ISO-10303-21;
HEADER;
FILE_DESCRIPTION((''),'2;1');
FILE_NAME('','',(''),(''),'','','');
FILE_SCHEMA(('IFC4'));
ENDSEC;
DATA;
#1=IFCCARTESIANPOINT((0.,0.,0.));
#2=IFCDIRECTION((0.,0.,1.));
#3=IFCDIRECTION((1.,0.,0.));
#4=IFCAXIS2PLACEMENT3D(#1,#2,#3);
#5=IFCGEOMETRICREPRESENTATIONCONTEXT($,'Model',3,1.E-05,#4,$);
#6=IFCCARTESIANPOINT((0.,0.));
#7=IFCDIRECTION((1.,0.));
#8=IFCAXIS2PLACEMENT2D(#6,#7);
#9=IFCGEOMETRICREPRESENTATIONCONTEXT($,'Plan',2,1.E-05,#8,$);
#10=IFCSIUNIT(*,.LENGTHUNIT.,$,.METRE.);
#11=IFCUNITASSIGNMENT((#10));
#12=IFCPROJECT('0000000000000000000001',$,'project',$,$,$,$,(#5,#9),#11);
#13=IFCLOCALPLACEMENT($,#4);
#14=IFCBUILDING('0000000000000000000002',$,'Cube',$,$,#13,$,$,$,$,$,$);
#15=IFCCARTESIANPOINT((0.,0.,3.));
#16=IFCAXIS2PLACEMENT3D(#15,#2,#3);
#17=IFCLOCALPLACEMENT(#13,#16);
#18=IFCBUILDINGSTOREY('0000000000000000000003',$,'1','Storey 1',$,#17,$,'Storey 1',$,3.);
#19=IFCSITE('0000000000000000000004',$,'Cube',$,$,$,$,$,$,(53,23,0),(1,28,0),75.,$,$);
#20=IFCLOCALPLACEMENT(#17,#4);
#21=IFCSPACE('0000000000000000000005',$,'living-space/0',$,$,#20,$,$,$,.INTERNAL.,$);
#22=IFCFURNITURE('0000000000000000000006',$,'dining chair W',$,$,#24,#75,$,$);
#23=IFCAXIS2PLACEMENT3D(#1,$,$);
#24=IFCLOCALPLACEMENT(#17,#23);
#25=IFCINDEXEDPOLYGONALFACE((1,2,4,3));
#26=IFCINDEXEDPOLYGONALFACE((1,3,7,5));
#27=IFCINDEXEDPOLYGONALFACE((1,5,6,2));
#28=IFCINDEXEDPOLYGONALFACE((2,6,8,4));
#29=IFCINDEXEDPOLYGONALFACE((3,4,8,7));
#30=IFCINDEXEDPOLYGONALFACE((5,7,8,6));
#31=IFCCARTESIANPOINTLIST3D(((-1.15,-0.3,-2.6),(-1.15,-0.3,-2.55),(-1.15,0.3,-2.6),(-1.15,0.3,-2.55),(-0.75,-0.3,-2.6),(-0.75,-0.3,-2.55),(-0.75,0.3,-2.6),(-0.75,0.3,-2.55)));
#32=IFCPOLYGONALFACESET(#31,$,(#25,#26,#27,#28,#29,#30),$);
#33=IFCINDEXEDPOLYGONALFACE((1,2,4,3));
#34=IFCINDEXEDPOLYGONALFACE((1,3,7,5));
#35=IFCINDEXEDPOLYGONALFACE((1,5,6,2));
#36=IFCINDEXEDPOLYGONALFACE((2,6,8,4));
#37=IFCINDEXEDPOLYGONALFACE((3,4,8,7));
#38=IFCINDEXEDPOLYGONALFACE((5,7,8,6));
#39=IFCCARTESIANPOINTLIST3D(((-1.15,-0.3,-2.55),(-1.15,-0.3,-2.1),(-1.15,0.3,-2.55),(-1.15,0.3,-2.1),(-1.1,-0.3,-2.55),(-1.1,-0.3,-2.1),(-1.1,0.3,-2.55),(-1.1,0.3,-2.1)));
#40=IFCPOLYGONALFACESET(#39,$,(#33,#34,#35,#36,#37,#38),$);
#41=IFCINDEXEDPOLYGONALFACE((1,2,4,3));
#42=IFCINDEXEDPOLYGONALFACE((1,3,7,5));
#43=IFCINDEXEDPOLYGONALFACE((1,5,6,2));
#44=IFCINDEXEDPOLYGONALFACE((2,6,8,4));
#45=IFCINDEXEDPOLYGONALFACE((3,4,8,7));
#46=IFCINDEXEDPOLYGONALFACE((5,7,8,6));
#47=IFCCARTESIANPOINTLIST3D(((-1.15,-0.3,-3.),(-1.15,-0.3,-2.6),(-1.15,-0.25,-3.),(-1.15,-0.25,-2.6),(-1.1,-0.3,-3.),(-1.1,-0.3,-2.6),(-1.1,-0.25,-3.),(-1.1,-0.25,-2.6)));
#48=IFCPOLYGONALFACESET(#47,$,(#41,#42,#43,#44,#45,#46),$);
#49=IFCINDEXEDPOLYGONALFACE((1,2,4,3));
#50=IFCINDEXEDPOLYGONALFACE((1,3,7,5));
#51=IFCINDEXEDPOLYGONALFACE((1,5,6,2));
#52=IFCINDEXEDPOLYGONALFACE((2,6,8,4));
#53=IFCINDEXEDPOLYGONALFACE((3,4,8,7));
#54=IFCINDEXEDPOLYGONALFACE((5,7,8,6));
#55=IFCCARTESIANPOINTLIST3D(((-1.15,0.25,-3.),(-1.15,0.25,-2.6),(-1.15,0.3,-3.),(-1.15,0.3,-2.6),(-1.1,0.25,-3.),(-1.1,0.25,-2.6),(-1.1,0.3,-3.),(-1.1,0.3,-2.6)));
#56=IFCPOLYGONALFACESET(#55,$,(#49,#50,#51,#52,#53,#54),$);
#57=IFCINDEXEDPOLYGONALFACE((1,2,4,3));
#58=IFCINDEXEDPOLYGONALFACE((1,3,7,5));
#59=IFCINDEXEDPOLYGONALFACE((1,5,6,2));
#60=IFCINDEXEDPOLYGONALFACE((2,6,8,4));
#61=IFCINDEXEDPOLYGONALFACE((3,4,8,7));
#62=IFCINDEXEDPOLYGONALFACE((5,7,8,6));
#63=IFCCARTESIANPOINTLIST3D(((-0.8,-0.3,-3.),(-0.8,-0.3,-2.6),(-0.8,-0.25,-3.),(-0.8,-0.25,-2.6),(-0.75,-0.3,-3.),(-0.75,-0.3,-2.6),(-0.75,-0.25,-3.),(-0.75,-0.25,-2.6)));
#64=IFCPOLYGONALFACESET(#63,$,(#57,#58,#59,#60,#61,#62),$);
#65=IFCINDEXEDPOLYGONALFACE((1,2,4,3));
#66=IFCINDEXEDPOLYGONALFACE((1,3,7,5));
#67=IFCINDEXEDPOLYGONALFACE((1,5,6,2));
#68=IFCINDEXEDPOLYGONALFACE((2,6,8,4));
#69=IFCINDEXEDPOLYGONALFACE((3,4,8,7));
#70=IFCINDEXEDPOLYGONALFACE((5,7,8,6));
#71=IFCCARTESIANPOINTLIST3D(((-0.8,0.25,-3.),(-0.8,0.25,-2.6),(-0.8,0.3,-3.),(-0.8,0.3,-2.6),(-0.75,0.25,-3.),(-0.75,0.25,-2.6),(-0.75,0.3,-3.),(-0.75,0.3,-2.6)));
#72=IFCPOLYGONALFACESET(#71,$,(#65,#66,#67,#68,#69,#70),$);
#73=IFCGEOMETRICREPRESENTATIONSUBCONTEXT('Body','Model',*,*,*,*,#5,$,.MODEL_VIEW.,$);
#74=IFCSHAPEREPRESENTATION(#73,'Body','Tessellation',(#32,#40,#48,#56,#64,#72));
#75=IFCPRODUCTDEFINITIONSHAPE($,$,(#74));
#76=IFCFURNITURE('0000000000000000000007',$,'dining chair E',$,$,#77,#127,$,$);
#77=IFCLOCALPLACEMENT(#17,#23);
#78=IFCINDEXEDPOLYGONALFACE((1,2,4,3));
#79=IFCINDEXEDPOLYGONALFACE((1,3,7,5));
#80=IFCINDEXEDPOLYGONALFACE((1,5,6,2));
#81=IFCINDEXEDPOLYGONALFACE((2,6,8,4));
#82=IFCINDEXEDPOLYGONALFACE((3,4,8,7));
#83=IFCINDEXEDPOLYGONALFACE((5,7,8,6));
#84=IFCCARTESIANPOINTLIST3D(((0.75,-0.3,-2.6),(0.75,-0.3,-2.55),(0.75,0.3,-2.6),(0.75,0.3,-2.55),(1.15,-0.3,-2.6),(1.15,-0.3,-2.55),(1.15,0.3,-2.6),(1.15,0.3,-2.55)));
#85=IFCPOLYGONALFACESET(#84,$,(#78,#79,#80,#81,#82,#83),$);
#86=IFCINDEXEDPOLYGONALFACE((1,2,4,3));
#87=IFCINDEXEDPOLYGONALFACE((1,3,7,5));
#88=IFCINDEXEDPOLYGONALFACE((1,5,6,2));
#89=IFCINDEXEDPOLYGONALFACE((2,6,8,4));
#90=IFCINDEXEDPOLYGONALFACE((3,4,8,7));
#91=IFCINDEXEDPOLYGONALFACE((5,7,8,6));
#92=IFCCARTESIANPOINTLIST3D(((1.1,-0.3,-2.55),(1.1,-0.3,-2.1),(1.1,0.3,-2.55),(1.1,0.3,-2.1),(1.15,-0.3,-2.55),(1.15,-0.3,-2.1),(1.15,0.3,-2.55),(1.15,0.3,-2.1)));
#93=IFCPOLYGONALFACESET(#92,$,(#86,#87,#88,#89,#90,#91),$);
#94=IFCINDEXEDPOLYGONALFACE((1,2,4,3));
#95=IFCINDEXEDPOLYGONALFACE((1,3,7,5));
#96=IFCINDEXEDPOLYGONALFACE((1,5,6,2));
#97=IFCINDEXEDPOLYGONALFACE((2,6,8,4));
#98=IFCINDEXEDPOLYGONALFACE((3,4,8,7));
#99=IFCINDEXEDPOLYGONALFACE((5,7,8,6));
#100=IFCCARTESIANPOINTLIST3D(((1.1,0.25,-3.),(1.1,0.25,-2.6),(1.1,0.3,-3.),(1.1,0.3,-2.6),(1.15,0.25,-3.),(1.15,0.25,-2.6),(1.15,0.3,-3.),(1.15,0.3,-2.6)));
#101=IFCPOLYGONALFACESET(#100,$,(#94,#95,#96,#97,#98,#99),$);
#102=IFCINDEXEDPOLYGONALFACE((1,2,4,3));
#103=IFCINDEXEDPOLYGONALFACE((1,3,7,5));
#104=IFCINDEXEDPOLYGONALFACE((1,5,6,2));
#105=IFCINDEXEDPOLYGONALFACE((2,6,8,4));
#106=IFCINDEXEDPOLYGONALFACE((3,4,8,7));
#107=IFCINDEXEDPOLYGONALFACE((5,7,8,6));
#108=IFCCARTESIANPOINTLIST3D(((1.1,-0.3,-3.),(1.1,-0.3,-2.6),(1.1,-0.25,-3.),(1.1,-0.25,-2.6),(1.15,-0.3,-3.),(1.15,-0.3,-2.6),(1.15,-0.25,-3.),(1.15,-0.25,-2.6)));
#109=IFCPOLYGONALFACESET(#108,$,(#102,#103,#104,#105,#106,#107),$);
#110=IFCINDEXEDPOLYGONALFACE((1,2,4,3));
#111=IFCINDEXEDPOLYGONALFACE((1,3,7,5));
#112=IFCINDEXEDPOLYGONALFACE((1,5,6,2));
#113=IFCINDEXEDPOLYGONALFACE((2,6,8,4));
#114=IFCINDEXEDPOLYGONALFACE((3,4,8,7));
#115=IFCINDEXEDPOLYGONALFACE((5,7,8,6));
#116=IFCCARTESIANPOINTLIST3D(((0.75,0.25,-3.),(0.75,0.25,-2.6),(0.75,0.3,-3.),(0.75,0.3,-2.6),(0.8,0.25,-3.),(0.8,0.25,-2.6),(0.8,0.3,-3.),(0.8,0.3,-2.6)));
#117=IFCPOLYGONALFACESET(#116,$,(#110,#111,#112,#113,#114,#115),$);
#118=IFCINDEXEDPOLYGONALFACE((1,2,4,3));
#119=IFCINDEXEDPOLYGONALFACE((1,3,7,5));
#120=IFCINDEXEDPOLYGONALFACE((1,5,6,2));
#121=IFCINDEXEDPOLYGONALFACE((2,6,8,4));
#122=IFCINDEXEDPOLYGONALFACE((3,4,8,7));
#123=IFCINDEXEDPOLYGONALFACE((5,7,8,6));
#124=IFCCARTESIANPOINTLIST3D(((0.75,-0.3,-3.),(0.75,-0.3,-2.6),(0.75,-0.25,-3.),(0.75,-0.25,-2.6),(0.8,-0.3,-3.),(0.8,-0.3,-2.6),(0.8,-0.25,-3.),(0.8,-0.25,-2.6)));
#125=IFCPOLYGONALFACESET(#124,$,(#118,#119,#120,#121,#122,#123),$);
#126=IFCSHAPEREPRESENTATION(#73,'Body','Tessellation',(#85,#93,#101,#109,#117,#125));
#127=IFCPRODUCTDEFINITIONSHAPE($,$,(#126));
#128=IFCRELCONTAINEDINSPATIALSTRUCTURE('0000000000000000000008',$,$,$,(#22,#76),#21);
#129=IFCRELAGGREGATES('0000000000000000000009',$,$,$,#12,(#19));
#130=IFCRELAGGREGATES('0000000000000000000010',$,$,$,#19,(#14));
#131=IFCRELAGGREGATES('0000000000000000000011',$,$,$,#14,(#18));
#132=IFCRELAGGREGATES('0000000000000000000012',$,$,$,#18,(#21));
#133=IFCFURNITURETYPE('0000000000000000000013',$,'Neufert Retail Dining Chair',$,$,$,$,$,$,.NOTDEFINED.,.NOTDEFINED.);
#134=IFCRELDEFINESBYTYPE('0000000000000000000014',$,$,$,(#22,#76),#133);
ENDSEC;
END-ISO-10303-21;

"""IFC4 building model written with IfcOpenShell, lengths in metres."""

from ifc_helpers import new_model, entity, si_unit, frame, origin_with_axes, origin_2d_with_axis, place, context, subcontext, project, spatial, line, indexed_curve, outline, extrude, shape, source, transform, mapped, type_object, type_shapes, element, save


model = new_model("IFC4")

# Units and contexts
model_context = context("Model", 3, precision=1e-05, world=origin_with_axes())
plan_context = context("Plan", 2, precision=1e-05, world=origin_2d_with_axis())
body_context_1 = subcontext(model_context, "Body", "Model", "MODEL_VIEW")
body_context_2 = subcontext(plan_context, "Body", "Plan", "PLAN_VIEW")
ifc_project = project(units=[si_unit("LENGTHUNIT", "METRE")], contexts=[model_context, plan_context])

# Site, building, storey
site = spatial("IfcSite", under=ifc_project, Name="Cube", RefLatitude=(53, 23, 0), RefLongitude=(1, 28, 0), RefElevation=75.0)
building_placement = place(None, origin_with_axes())
building = spatial("IfcBuilding", under=site, at=building_placement, Name="Cube")
storey_placement = place(building_placement, frame((0.0, 0.0, 3.0), z_axis=(0.0, 0.0, 1.0), x_axis=(1.0, 0.0, 0.0)))
storey = spatial("IfcBuildingStorey", under=building, at=storey_placement, Name="1", Description="Storey 1", LongName="Storey 1", Elevation=3.0)

# Shared definitions
space_placement = place(storey_placement, origin_with_axes())
space = spatial("IfcSpace", under=storey, at=space_placement, Name="living-space/0", PredefinedType="INTERNAL")

# Furniture
furniture_type_1 = type_object("IfcFurnitureType", Name="Neufert Retail Dining Chair", AssemblyPlace="NOTDEFINED", PredefinedType="NOTDEFINED")
shared_shape_1 = source(origin_with_axes(), body_context_1, "Body", "SweptSolid", [
    extrude(outline(indexed_curve([(-0.3, 0.0), (0.3, 0.0), (0.3, -0.4), (-0.3, -0.4)], segments=[line(1, 2, 3, 4, 1)])), frame((0.0, 0.0, 0.45), z_axis=(0.0, 0.0, 1.0), x_axis=(1.0, 0.0, 0.0)), (0.0, 0.0, -1.0), 0.05),
    extrude(outline(indexed_curve([(-0.3, 0.0), (0.3, 0.0), (0.3, -0.05), (-0.3, -0.05)], segments=[line(1, 2, 3, 4, 1)])), frame((0.0, 0.0, 0.9), z_axis=(0.0, 0.0, 1.0), x_axis=(1.0, 0.0, 0.0)), (0.0, 0.0, -1.0), 0.45),
    extrude(outline(indexed_curve([(-0.3, 0.0), (-0.25, 0.0), (-0.25, -0.05), (-0.3, -0.05)], segments=[line(1, 2, 3, 4, 1)])), origin_with_axes(), (0.0, 0.0, 1.0), 0.4),
    extrude(outline(indexed_curve([(0.3, 0.0), (0.25, 0.0), (0.25, -0.05), (0.3, -0.05)], segments=[line(1, 2, 3, 4, 1)])), origin_with_axes(), (0.0, 0.0, 1.0), 0.4),
    extrude(outline(indexed_curve([(-0.3, -0.4), (-0.25, -0.4), (-0.25, -0.35), (-0.3, -0.35)], segments=[line(1, 2, 3, 4, 1)])), origin_with_axes(), (0.0, 0.0, 1.0), 0.4),
    extrude(outline(indexed_curve([(0.3, -0.4), (0.25, -0.4), (0.25, -0.35), (0.3, -0.35)], segments=[line(1, 2, 3, 4, 1)])), origin_with_axes(), (0.0, 0.0, 1.0), 0.4),
])
shared_shape_2 = source(origin_with_axes(), body_context_2, "Body", "Curve2D", [
    entity("IfcIndexedPolyCurve", entity("IfcCartesianPointList2D", [[-0.3, -0.4], [0.3, -0.4]])),
    entity("IfcIndexedPolyCurve", entity("IfcCartesianPointList2D", [[-0.3, -0.4], [-0.3, -0.3], [-0.2121, -0.0879], [0.0, 0.0], [0.2121, -0.0879], [0.3, -0.3], [0.3, -0.4]]), [entity("IfcLineIndex", [1, 2]), entity("IfcArcIndex", [2, 3, 4]), entity("IfcArcIndex", [4, 5, 6]), entity("IfcLineIndex", [6, 7])]),
    entity("IfcIndexedPolyCurve", entity("IfcCartesianPointList2D", [[-0.26, -0.4], [-0.26, -0.3], [-0.1838, -0.1162], [0.0, -0.04], [0.1838, -0.1162], [0.26, -0.3], [0.26, -0.4]]), [entity("IfcLineIndex", [1, 2]), entity("IfcArcIndex", [2, 3, 4]), entity("IfcArcIndex", [4, 5, 6]), entity("IfcLineIndex", [6, 7])]),
])
type_shapes(furniture_type_1, [shared_shape_1, shared_shape_2])
for number, where, z_axis, x_axis, name in (
    (1, (-1.15, 0.0, -3.0), (0.0, 0.0, 1.0), (0.0, 1.0, 0.0), "dining chair W"),
    (2, (1.15, 0.0, -3.0), (0.0, 0.0, 1.0), (0.0, -1.0, 0.0), "dining chair E"),
):
    element("IfcFurniture", number, at=place(space_placement, frame(where, z_axis=z_axis, x_axis=x_axis)), inside=space, type_object=furniture_type_1, Name=name, shapes=[
        shape(body_context_1, "Body", "MappedRepresentation", [mapped(shared_shape_1, transform((0.0, 0.0, 0.0), x_axis=(1.0, 0.0, 0.0), y_axis=(0.0, 1.0, 0.0), z_axis=(0.0, 0.0, 1.0), scale=1.0))]),
        shape(body_context_2, "Body", "MappedRepresentation", [mapped(shared_shape_2, transform((0.0, 0.0, 0.0), x_axis=(1.0, 0.0, 0.0), y_axis=(0.0, 1.0, 0.0), z_axis=(0.0, 0.0, 1.0), scale=1.0))]),
    ])

save(model, "model.ifc")
